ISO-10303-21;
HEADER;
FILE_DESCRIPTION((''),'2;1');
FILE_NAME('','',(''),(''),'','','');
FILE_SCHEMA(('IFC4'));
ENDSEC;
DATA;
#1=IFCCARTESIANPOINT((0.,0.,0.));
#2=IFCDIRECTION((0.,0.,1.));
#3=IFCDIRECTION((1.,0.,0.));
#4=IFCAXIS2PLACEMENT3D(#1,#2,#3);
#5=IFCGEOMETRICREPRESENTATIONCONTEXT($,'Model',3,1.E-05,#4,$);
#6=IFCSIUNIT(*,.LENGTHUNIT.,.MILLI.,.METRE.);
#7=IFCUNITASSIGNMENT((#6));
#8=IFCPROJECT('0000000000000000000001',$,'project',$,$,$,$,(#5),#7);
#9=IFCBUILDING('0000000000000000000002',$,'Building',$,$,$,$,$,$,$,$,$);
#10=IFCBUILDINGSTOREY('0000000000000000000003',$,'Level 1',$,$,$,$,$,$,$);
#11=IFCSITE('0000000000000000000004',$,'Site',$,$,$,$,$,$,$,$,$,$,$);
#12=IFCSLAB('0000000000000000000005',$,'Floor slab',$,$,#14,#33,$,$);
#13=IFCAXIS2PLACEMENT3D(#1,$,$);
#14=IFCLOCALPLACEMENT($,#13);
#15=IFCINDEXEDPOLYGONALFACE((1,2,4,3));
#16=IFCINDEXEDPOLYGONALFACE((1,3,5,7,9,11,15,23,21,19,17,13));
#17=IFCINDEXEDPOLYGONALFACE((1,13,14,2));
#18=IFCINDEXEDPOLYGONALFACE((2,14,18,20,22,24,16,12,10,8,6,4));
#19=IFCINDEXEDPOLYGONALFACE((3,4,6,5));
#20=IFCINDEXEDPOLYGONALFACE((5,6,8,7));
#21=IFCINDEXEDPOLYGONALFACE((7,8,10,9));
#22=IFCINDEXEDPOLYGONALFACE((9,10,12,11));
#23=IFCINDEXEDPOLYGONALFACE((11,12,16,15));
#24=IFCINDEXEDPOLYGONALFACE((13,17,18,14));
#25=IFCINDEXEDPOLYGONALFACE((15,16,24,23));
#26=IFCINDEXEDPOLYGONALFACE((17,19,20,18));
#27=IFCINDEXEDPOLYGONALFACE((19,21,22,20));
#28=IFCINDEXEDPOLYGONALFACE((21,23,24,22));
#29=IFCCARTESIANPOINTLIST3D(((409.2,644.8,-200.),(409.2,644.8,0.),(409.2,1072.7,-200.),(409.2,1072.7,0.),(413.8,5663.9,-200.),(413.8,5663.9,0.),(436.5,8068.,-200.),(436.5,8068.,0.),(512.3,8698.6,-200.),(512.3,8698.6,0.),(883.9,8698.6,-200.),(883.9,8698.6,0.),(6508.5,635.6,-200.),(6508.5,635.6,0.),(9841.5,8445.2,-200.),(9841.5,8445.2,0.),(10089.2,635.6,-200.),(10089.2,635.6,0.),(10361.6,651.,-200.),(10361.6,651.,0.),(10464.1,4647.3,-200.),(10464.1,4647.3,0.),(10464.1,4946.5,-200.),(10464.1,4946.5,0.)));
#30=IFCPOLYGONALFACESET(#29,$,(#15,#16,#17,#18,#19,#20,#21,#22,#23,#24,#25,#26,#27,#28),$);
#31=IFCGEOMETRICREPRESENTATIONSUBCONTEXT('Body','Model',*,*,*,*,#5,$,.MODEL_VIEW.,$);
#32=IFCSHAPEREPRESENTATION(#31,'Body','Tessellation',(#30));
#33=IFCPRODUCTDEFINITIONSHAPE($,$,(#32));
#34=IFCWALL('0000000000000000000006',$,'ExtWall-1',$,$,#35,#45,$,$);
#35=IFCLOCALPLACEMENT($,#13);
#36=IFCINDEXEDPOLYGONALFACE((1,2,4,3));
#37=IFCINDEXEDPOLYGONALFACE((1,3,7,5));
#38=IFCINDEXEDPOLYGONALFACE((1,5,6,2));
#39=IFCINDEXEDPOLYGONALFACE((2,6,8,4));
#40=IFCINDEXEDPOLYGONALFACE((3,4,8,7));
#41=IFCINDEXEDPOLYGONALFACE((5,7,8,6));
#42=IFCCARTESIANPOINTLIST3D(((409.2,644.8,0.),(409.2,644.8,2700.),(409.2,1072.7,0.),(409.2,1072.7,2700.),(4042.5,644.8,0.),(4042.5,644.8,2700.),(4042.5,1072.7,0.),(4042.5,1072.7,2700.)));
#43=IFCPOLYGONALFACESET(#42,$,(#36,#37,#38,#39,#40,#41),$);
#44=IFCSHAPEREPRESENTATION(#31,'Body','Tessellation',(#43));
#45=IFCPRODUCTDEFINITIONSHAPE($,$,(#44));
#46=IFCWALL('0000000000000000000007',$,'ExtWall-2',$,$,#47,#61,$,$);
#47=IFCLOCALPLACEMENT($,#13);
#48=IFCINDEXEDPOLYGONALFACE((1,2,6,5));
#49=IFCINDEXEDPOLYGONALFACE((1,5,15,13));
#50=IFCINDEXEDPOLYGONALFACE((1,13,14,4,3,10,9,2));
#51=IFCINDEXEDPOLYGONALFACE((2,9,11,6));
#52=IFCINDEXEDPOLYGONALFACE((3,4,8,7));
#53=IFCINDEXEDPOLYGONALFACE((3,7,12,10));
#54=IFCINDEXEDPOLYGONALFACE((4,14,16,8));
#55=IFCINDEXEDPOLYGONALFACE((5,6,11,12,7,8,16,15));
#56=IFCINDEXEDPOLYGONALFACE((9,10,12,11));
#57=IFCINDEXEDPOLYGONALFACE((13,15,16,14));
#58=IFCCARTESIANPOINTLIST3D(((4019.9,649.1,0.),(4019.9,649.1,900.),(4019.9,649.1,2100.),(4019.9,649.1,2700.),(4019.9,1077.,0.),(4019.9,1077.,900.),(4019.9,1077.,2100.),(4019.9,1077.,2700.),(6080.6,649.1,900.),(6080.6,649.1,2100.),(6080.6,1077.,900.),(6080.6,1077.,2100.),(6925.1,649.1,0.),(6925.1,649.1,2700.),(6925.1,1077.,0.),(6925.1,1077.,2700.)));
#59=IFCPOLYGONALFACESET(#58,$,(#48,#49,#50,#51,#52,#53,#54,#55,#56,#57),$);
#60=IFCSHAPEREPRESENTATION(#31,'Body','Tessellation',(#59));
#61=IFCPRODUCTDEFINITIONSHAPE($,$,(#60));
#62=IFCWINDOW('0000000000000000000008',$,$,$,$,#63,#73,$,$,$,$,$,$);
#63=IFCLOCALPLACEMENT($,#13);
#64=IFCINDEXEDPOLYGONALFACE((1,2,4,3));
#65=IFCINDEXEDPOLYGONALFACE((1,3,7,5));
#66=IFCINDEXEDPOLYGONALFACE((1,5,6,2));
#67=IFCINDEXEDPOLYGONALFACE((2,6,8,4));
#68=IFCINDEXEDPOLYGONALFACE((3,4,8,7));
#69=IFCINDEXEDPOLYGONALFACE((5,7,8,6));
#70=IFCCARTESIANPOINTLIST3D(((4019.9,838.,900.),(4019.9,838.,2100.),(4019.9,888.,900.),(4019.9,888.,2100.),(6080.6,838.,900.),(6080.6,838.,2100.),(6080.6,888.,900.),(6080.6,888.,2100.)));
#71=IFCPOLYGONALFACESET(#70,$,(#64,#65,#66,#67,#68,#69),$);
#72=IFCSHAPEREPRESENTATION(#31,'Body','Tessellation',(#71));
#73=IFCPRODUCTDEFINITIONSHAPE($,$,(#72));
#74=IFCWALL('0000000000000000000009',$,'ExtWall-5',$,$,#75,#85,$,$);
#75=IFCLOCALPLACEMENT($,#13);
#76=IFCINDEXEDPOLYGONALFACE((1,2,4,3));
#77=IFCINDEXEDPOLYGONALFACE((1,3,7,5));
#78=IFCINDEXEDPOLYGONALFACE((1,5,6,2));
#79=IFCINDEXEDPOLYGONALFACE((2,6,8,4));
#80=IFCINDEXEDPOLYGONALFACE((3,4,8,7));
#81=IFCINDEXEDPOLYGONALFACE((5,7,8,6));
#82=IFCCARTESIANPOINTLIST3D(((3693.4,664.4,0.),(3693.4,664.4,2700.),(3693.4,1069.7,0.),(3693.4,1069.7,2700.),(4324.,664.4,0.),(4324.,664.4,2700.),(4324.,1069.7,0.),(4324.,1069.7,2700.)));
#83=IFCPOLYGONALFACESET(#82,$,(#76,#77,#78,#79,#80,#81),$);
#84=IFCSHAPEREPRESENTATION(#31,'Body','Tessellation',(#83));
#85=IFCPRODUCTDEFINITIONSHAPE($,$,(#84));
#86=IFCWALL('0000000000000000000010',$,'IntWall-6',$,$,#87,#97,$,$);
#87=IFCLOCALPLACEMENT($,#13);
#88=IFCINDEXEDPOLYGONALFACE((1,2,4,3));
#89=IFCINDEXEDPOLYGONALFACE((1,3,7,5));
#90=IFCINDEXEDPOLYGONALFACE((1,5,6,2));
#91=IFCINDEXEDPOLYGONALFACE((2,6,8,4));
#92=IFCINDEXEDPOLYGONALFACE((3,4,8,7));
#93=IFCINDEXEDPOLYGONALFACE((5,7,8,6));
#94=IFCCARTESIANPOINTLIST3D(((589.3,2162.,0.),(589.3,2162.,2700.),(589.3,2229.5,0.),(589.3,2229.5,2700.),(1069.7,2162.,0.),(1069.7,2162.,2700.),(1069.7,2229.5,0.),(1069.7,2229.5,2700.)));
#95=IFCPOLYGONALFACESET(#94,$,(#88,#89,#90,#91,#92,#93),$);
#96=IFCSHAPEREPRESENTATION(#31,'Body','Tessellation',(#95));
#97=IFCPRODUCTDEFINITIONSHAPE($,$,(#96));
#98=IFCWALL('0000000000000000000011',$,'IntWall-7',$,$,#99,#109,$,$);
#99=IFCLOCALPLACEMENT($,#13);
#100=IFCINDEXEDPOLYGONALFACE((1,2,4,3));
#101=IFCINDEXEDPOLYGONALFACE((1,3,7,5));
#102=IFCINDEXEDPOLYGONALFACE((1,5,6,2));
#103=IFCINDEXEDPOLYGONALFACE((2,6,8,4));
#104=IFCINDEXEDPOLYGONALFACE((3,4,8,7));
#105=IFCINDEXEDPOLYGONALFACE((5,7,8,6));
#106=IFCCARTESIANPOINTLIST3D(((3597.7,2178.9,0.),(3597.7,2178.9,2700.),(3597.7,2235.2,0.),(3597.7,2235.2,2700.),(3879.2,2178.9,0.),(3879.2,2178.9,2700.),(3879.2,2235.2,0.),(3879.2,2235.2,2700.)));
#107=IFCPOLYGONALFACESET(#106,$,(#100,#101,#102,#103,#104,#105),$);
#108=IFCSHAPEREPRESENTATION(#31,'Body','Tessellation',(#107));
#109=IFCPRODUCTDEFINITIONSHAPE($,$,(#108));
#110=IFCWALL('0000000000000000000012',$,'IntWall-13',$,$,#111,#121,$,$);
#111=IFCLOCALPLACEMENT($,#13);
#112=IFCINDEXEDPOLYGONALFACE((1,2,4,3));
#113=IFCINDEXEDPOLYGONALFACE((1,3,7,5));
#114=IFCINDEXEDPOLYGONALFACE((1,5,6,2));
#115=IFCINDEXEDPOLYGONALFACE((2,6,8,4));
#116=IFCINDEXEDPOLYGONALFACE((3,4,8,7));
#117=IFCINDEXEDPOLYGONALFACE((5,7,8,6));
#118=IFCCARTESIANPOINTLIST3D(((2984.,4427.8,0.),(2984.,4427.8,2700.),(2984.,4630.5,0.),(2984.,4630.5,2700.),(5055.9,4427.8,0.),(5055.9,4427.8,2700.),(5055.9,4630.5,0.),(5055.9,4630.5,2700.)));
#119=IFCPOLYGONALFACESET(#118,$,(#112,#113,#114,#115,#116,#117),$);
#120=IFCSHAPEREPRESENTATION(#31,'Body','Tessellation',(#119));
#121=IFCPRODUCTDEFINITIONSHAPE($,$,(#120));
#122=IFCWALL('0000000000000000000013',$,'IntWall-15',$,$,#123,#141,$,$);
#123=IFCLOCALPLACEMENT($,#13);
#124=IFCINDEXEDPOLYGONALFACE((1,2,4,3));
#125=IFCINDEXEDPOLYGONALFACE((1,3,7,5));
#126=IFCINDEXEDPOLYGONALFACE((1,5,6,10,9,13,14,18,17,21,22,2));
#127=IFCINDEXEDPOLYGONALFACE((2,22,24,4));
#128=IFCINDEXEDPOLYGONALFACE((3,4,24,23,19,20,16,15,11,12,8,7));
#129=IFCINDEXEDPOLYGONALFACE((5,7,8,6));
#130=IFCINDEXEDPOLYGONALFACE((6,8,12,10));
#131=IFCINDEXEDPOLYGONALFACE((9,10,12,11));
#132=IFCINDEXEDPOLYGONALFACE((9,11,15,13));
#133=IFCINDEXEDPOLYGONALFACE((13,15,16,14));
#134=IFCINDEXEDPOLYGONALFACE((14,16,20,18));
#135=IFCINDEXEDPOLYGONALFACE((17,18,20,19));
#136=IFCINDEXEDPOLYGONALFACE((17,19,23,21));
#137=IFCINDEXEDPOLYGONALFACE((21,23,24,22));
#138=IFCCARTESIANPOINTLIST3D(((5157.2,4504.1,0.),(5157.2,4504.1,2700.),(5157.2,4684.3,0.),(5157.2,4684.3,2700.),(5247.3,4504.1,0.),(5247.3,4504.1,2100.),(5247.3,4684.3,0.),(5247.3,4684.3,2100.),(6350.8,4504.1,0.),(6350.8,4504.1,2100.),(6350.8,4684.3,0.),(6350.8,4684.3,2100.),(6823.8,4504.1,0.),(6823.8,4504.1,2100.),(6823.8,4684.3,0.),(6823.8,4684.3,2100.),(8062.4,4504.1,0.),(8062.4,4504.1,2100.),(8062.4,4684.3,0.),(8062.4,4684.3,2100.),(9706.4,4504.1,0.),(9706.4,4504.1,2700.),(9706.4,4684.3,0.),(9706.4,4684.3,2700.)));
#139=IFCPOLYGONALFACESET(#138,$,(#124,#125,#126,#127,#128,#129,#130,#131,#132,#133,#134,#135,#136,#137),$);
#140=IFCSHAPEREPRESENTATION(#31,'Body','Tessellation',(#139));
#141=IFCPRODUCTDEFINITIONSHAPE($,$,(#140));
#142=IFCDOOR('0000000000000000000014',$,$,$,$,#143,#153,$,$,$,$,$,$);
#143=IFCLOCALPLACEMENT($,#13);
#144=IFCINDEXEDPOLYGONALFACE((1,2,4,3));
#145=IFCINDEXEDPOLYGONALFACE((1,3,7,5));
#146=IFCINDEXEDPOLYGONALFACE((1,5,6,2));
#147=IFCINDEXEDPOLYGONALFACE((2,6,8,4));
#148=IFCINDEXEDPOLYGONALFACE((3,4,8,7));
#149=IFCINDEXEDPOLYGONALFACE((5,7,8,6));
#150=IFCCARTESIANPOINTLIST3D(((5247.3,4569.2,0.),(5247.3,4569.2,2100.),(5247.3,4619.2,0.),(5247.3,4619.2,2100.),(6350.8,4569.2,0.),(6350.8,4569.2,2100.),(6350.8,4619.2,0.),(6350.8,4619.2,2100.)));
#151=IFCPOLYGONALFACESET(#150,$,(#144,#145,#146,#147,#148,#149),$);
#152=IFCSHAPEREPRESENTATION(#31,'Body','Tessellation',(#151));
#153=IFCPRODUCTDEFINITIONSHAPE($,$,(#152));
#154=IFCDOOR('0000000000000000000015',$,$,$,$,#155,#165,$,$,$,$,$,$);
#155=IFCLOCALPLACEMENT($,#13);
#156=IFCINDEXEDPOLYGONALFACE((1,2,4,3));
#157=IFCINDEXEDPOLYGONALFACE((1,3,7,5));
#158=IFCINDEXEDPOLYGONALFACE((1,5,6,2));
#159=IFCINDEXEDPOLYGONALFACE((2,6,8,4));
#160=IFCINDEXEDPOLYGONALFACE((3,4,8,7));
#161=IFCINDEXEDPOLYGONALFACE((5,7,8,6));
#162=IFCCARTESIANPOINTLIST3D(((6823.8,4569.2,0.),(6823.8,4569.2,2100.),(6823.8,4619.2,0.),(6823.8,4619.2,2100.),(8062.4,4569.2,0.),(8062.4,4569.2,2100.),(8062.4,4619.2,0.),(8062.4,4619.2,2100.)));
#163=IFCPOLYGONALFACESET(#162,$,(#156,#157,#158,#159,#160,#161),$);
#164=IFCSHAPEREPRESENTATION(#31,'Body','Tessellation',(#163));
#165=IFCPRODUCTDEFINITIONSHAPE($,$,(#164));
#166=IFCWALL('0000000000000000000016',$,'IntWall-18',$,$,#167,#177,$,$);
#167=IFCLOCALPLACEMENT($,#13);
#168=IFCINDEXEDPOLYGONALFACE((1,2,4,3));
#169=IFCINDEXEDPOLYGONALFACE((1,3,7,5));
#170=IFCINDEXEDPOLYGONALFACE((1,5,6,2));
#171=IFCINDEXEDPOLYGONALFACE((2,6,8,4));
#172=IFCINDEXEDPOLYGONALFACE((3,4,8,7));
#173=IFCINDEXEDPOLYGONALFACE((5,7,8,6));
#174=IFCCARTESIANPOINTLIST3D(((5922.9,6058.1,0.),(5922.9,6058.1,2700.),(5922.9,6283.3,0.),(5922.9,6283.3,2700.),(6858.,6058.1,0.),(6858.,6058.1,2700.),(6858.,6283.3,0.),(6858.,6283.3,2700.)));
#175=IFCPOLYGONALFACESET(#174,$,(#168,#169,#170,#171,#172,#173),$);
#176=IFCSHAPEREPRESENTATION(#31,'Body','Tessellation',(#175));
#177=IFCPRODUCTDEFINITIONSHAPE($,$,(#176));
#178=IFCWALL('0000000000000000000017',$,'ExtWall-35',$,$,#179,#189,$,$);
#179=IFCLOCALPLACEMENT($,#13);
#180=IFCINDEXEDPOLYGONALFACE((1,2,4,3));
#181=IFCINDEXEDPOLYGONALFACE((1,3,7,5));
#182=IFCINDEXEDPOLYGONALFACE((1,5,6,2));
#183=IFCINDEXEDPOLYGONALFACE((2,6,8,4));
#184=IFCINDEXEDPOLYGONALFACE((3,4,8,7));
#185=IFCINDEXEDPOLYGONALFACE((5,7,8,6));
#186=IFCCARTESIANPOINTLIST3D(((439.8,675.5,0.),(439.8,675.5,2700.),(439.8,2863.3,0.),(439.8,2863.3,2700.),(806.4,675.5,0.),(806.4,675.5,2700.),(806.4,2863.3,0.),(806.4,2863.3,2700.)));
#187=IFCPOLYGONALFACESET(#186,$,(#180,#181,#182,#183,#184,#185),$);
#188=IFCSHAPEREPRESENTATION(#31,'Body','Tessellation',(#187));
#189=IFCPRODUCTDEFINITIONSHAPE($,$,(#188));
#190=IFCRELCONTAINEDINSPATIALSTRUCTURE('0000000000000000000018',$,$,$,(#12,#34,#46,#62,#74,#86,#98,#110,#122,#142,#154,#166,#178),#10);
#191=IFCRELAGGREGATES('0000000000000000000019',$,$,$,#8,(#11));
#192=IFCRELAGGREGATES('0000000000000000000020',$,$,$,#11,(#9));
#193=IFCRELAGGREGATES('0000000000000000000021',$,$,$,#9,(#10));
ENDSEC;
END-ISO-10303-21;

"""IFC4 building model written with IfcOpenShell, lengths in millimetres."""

from ifc_helpers import new_model, si_unit, frame, origin_with_axes, place, context, subcontext, project, spatial, indexed_curve, outline, extrude, element, fill, save


model = new_model("IFC4")

# Units and contexts
model_context = context("Model", 3, precision=1e-05, world=origin_with_axes())
body_context = subcontext(model_context, "Body", "Model", "MODEL_VIEW")
ifc_project = project(units=[si_unit("LENGTHUNIT", "METRE", prefix="MILLI")], contexts=[model_context])

# Site, building, storey
site = spatial("IfcSite", under=ifc_project, Name="Site")
building = spatial("IfcBuilding", under=site, Name="Building")
storey = spatial("IfcBuildingStorey", under=building, Name="Level 1")

# Slab
slab_placement = place(None, frame((0.0, 0.0, -200.0), z_axis=(0.0, 0.0, 1.0), x_axis=(1.0, 0.0, 0.0)))
element("IfcSlab", 1, at=slab_placement, inside=storey, Name="Floor slab", context=body_context, shape_type="SweptSolid", body=[
    extrude(outline(indexed_curve([(6508.5, 635.6), (409.2, 644.8), (409.2, 1072.7), (413.8, 5663.9), (436.5, 8068.0), (512.3, 8698.6), (883.9, 8698.6), (9841.5, 8445.2), (10464.1, 4946.5), (10464.1, 4647.3), (10361.6, 651.0), (10089.2, 635.6)])), None, (0.0, 0.0, 1.0), 200.0),
])

# Wall
wall_1_placement = place(None, frame((409.2, 858.8, 0.0), z_axis=(0.0, 0.0, 1.0), x_axis=(1.0, 0.0, 0.0)))
element("IfcWall", 2, at=wall_1_placement, inside=storey, Name="ExtWall-1", context=body_context, shape_type="SweptSolid", body=[
    extrude(outline(indexed_curve([(0.0, 0.0), (0.0, 427.9), (3633.3, 427.9), (3633.3, 0.0), (0.0, 0.0)], self_intersect=False)), frame((0.0, -213.9, 0.0), z_axis=(0.0, 0.0, 1.0), x_axis=(1.0, 0.0, 0.0)), (0.0, 0.0, 1.0), 2700.0),
])

# Wall, opening, window
wall_2_placement = place(None, frame((4019.9, 863.0, 0.0), z_axis=(0.0, 0.0, 1.0), x_axis=(1.0, 0.0, 0.0)))
wall_2 = element("IfcWall", 3, at=wall_2_placement, inside=storey, Name="ExtWall-2", context=body_context, shape_type="SweptSolid", body=[
    extrude(outline(indexed_curve([(0.0, 0.0), (0.0, 427.9), (2905.2, 427.9), (2905.2, 0.0), (0.0, 0.0)], self_intersect=False)), frame((0.0, -213.9, 0.0), z_axis=(0.0, 0.0, 1.0), x_axis=(1.0, 0.0, 0.0)), (0.0, 0.0, 1.0), 2700.0),
])
opening_1_placement = place(wall_2_placement, frame((0.0, 0.0, 900.0), z_axis=(0.0, 0.0, 1.0), x_axis=(1.0, 0.0, 0.0)))
opening_1 = element("IfcOpeningElement", 4, at=opening_1_placement, cuts=wall_2, context=body_context, shape_type="SweptSolid", body=[
    extrude(outline(indexed_curve([(0.0, 0.0), (0.0, 527.9), (2060.6, 527.9), (2060.6, 0.0), (0.0, 0.0)], self_intersect=False)), frame((0.0, -263.9, 0.0), z_axis=(0.0, 0.0, 1.0), x_axis=(1.0, 0.0, 0.0)), (0.0, 0.0, 1.0), 1200.0),
])
window_1_placement = place(opening_1_placement, origin_with_axes())
window_1 = element("IfcWindow", 5, at=window_1_placement, inside=storey, context=body_context, shape_type="SweptSolid", body=[
    extrude(outline(indexed_curve([(0.0, 0.0), (0.0, 50.0), (2060.6, 50.0), (2060.6, 0.0), (0.0, 0.0)], self_intersect=False)), frame((0.0, -25.0, 0.0), z_axis=(0.0, 0.0, 1.0), x_axis=(1.0, 0.0, 0.0)), (0.0, 0.0, 1.0), 1200.0),
])
fill(opening_1, window_1)

# Walls
wall_3_placement = place(None, frame((3693.4, 867.0, 0.0), z_axis=(0.0, 0.0, 1.0), x_axis=(1.0, 0.0, 0.0)))
element("IfcWall", 6, at=wall_3_placement, inside=storey, Name="ExtWall-5", context=body_context, shape_type="SweptSolid", body=[
    extrude(outline(indexed_curve([(0.0, 0.0), (0.0, 405.4), (630.6, 405.4), (630.6, 0.0), (0.0, 0.0)], self_intersect=False)), frame((0.0, -202.7, 0.0), z_axis=(0.0, 0.0, 1.0), x_axis=(1.0, 0.0, 0.0)), (0.0, 0.0, 1.0), 2700.0),
])
wall_4_placement = place(None, frame((589.3, 2195.8, 0.0), z_axis=(0.0, 0.0, 1.0), x_axis=(1.0, 0.0, 0.0)))
element("IfcWall", 7, at=wall_4_placement, inside=storey, Name="IntWall-6", context=body_context, shape_type="SweptSolid", body=[
    extrude(outline(indexed_curve([(0.0, 0.0), (0.0, 67.6), (480.4, 67.6), (480.4, 0.0), (0.0, 0.0)], self_intersect=False)), frame((0.0, -33.8, 0.0), z_axis=(0.0, 0.0, 1.0), x_axis=(1.0, 0.0, 0.0)), (0.0, 0.0, 1.0), 2700.0),
])
wall_5_placement = place(None, frame((3597.7, 2207.0, 0.0), z_axis=(0.0, 0.0, 1.0), x_axis=(1.0, 0.0, 0.0)))
element("IfcWall", 8, at=wall_5_placement, inside=storey, Name="IntWall-7", context=body_context, shape_type="SweptSolid", body=[
    extrude(outline(indexed_curve([(0.0, 0.0), (0.0, 56.3), (281.5, 56.3), (281.5, 0.0), (0.0, 0.0)], self_intersect=False)), frame((0.0, -28.2, 0.0), z_axis=(0.0, 0.0, 1.0), x_axis=(1.0, 0.0, 0.0)), (0.0, 0.0, 1.0), 2700.0),
])
wall_6_placement = place(None, frame((2984.0, 4529.2, 0.0), z_axis=(0.0, 0.0, 1.0), x_axis=(1.0, 0.0, 0.0)))
element("IfcWall", 9, at=wall_6_placement, inside=storey, Name="IntWall-13", context=body_context, shape_type="SweptSolid", body=[
    extrude(outline(indexed_curve([(0.0, 0.0), (0.0, 202.7), (2071.9, 202.7), (2071.9, 0.0), (0.0, 0.0)], self_intersect=False)), frame((0.0, -101.3, 0.0), z_axis=(0.0, 0.0, 1.0), x_axis=(1.0, 0.0, 0.0)), (0.0, 0.0, 1.0), 2700.0),
])

# Wall, openings, doors
wall_7_placement = place(None, frame((5157.2, 4594.2, 0.0), z_axis=(0.0, 0.0, 1.0), x_axis=(1.0, 0.0, 0.0)))
wall_7 = element("IfcWall", 10, at=wall_7_placement, inside=storey, Name="IntWall-15", context=body_context, shape_type="SweptSolid", body=[
    extrude(outline(indexed_curve([(0.0, 0.0), (0.0, 180.2), (4549.2, 180.2), (4549.2, 0.0), (0.0, 0.0)], self_intersect=False)), frame((0.0, -90.1, 0.0), z_axis=(0.0, 0.0, 1.0), x_axis=(1.0, 0.0, 0.0)), (0.0, 0.0, 1.0), 2700.0),
])
opening_2_placement = place(wall_7_placement, frame((90.1, 0.0, 0.0), z_axis=(0.0, 0.0, 1.0), x_axis=(1.0, 0.0, 0.0)))
opening_2 = element("IfcOpeningElement", 11, at=opening_2_placement, cuts=wall_7, context=body_context, shape_type="SweptSolid", body=[
    extrude(outline(indexed_curve([(0.0, 0.0), (0.0, 280.2), (1103.5, 280.2), (1103.5, 0.0), (0.0, 0.0)], self_intersect=False)), frame((0.0, -140.1, 0.0), z_axis=(0.0, 0.0, 1.0), x_axis=(1.0, 0.0, 0.0)), (0.0, 0.0, 1.0), 2100.0),
])
opening_3_placement = place(wall_7_placement, frame((1666.5, 0.0, 0.0), z_axis=(0.0, 0.0, 1.0), x_axis=(1.0, 0.0, 0.0)))
opening_3 = element("IfcOpeningElement", 12, at=opening_3_placement, cuts=wall_7, context=body_context, shape_type="SweptSolid", body=[
    extrude(outline(indexed_curve([(0.0, 0.0), (0.0, 280.2), (1238.6, 280.2), (1238.6, 0.0), (0.0, 0.0)], self_intersect=False)), frame((0.0, -140.1, 0.0), z_axis=(0.0, 0.0, 1.0), x_axis=(1.0, 0.0, 0.0)), (0.0, 0.0, 1.0), 2100.0),
])
door_1_placement = place(opening_2_placement, origin_with_axes())
door_1 = element("IfcDoor", 13, at=door_1_placement, inside=storey, context=body_context, shape_type="SweptSolid", body=[
    extrude(outline(indexed_curve([(0.0, 0.0), (0.0, 50.0), (1103.5, 50.0), (1103.5, 0.0), (0.0, 0.0)], self_intersect=False)), frame((0.0, -25.0, 0.0), z_axis=(0.0, 0.0, 1.0), x_axis=(1.0, 0.0, 0.0)), (0.0, 0.0, 1.0), 2100.0),
])
fill(opening_2, door_1)
door_2_placement = place(opening_3_placement, origin_with_axes())
door_2 = element("IfcDoor", 14, at=door_2_placement, inside=storey, context=body_context, shape_type="SweptSolid", body=[
    extrude(outline(indexed_curve([(0.0, 0.0), (0.0, 50.0), (1238.6, 50.0), (1238.6, 0.0), (0.0, 0.0)], self_intersect=False)), frame((0.0, -25.0, 0.0), z_axis=(0.0, 0.0, 1.0), x_axis=(1.0, 0.0, 0.0)), (0.0, 0.0, 1.0), 2100.0),
])
fill(opening_3, door_2)

# Walls
wall_8_placement = place(None, frame((5922.9, 6170.7, 0.0), z_axis=(0.0, 0.0, 1.0), x_axis=(1.0, 0.0, 0.0)))
element("IfcWall", 15, at=wall_8_placement, inside=storey, Name="IntWall-18", context=body_context, shape_type="SweptSolid", body=[
    extrude(outline(indexed_curve([(0.0, 0.0), (0.0, 225.2), (935.1, 225.2), (935.1, 0.0), (0.0, 0.0)], self_intersect=False)), frame((0.0, -112.6, 0.0), z_axis=(0.0, 0.0, 1.0), x_axis=(1.0, 0.0, 0.0)), (0.0, 0.0, 1.0), 2700.0),
])
wall_9_placement = place(None, frame((623.1, 675.5, 0.0), z_axis=(0.0, 0.0, 1.0), x_axis=(0.0, 1.0, 0.0)))
element("IfcWall", 16, at=wall_9_placement, inside=storey, Name="ExtWall-35", context=body_context, shape_type="SweptSolid", body=[
    extrude(outline(indexed_curve([(0.0, 0.0), (0.0, 366.6), (2187.8, 366.6), (2187.8, 0.0), (0.0, 0.0)], self_intersect=False)), frame((0.0, -183.3, 0.0), z_axis=(0.0, 0.0, 1.0), x_axis=(1.0, 0.0, 0.0)), (0.0, 0.0, 1.0), 2700.0),
])

save(model, "model.ifc")
